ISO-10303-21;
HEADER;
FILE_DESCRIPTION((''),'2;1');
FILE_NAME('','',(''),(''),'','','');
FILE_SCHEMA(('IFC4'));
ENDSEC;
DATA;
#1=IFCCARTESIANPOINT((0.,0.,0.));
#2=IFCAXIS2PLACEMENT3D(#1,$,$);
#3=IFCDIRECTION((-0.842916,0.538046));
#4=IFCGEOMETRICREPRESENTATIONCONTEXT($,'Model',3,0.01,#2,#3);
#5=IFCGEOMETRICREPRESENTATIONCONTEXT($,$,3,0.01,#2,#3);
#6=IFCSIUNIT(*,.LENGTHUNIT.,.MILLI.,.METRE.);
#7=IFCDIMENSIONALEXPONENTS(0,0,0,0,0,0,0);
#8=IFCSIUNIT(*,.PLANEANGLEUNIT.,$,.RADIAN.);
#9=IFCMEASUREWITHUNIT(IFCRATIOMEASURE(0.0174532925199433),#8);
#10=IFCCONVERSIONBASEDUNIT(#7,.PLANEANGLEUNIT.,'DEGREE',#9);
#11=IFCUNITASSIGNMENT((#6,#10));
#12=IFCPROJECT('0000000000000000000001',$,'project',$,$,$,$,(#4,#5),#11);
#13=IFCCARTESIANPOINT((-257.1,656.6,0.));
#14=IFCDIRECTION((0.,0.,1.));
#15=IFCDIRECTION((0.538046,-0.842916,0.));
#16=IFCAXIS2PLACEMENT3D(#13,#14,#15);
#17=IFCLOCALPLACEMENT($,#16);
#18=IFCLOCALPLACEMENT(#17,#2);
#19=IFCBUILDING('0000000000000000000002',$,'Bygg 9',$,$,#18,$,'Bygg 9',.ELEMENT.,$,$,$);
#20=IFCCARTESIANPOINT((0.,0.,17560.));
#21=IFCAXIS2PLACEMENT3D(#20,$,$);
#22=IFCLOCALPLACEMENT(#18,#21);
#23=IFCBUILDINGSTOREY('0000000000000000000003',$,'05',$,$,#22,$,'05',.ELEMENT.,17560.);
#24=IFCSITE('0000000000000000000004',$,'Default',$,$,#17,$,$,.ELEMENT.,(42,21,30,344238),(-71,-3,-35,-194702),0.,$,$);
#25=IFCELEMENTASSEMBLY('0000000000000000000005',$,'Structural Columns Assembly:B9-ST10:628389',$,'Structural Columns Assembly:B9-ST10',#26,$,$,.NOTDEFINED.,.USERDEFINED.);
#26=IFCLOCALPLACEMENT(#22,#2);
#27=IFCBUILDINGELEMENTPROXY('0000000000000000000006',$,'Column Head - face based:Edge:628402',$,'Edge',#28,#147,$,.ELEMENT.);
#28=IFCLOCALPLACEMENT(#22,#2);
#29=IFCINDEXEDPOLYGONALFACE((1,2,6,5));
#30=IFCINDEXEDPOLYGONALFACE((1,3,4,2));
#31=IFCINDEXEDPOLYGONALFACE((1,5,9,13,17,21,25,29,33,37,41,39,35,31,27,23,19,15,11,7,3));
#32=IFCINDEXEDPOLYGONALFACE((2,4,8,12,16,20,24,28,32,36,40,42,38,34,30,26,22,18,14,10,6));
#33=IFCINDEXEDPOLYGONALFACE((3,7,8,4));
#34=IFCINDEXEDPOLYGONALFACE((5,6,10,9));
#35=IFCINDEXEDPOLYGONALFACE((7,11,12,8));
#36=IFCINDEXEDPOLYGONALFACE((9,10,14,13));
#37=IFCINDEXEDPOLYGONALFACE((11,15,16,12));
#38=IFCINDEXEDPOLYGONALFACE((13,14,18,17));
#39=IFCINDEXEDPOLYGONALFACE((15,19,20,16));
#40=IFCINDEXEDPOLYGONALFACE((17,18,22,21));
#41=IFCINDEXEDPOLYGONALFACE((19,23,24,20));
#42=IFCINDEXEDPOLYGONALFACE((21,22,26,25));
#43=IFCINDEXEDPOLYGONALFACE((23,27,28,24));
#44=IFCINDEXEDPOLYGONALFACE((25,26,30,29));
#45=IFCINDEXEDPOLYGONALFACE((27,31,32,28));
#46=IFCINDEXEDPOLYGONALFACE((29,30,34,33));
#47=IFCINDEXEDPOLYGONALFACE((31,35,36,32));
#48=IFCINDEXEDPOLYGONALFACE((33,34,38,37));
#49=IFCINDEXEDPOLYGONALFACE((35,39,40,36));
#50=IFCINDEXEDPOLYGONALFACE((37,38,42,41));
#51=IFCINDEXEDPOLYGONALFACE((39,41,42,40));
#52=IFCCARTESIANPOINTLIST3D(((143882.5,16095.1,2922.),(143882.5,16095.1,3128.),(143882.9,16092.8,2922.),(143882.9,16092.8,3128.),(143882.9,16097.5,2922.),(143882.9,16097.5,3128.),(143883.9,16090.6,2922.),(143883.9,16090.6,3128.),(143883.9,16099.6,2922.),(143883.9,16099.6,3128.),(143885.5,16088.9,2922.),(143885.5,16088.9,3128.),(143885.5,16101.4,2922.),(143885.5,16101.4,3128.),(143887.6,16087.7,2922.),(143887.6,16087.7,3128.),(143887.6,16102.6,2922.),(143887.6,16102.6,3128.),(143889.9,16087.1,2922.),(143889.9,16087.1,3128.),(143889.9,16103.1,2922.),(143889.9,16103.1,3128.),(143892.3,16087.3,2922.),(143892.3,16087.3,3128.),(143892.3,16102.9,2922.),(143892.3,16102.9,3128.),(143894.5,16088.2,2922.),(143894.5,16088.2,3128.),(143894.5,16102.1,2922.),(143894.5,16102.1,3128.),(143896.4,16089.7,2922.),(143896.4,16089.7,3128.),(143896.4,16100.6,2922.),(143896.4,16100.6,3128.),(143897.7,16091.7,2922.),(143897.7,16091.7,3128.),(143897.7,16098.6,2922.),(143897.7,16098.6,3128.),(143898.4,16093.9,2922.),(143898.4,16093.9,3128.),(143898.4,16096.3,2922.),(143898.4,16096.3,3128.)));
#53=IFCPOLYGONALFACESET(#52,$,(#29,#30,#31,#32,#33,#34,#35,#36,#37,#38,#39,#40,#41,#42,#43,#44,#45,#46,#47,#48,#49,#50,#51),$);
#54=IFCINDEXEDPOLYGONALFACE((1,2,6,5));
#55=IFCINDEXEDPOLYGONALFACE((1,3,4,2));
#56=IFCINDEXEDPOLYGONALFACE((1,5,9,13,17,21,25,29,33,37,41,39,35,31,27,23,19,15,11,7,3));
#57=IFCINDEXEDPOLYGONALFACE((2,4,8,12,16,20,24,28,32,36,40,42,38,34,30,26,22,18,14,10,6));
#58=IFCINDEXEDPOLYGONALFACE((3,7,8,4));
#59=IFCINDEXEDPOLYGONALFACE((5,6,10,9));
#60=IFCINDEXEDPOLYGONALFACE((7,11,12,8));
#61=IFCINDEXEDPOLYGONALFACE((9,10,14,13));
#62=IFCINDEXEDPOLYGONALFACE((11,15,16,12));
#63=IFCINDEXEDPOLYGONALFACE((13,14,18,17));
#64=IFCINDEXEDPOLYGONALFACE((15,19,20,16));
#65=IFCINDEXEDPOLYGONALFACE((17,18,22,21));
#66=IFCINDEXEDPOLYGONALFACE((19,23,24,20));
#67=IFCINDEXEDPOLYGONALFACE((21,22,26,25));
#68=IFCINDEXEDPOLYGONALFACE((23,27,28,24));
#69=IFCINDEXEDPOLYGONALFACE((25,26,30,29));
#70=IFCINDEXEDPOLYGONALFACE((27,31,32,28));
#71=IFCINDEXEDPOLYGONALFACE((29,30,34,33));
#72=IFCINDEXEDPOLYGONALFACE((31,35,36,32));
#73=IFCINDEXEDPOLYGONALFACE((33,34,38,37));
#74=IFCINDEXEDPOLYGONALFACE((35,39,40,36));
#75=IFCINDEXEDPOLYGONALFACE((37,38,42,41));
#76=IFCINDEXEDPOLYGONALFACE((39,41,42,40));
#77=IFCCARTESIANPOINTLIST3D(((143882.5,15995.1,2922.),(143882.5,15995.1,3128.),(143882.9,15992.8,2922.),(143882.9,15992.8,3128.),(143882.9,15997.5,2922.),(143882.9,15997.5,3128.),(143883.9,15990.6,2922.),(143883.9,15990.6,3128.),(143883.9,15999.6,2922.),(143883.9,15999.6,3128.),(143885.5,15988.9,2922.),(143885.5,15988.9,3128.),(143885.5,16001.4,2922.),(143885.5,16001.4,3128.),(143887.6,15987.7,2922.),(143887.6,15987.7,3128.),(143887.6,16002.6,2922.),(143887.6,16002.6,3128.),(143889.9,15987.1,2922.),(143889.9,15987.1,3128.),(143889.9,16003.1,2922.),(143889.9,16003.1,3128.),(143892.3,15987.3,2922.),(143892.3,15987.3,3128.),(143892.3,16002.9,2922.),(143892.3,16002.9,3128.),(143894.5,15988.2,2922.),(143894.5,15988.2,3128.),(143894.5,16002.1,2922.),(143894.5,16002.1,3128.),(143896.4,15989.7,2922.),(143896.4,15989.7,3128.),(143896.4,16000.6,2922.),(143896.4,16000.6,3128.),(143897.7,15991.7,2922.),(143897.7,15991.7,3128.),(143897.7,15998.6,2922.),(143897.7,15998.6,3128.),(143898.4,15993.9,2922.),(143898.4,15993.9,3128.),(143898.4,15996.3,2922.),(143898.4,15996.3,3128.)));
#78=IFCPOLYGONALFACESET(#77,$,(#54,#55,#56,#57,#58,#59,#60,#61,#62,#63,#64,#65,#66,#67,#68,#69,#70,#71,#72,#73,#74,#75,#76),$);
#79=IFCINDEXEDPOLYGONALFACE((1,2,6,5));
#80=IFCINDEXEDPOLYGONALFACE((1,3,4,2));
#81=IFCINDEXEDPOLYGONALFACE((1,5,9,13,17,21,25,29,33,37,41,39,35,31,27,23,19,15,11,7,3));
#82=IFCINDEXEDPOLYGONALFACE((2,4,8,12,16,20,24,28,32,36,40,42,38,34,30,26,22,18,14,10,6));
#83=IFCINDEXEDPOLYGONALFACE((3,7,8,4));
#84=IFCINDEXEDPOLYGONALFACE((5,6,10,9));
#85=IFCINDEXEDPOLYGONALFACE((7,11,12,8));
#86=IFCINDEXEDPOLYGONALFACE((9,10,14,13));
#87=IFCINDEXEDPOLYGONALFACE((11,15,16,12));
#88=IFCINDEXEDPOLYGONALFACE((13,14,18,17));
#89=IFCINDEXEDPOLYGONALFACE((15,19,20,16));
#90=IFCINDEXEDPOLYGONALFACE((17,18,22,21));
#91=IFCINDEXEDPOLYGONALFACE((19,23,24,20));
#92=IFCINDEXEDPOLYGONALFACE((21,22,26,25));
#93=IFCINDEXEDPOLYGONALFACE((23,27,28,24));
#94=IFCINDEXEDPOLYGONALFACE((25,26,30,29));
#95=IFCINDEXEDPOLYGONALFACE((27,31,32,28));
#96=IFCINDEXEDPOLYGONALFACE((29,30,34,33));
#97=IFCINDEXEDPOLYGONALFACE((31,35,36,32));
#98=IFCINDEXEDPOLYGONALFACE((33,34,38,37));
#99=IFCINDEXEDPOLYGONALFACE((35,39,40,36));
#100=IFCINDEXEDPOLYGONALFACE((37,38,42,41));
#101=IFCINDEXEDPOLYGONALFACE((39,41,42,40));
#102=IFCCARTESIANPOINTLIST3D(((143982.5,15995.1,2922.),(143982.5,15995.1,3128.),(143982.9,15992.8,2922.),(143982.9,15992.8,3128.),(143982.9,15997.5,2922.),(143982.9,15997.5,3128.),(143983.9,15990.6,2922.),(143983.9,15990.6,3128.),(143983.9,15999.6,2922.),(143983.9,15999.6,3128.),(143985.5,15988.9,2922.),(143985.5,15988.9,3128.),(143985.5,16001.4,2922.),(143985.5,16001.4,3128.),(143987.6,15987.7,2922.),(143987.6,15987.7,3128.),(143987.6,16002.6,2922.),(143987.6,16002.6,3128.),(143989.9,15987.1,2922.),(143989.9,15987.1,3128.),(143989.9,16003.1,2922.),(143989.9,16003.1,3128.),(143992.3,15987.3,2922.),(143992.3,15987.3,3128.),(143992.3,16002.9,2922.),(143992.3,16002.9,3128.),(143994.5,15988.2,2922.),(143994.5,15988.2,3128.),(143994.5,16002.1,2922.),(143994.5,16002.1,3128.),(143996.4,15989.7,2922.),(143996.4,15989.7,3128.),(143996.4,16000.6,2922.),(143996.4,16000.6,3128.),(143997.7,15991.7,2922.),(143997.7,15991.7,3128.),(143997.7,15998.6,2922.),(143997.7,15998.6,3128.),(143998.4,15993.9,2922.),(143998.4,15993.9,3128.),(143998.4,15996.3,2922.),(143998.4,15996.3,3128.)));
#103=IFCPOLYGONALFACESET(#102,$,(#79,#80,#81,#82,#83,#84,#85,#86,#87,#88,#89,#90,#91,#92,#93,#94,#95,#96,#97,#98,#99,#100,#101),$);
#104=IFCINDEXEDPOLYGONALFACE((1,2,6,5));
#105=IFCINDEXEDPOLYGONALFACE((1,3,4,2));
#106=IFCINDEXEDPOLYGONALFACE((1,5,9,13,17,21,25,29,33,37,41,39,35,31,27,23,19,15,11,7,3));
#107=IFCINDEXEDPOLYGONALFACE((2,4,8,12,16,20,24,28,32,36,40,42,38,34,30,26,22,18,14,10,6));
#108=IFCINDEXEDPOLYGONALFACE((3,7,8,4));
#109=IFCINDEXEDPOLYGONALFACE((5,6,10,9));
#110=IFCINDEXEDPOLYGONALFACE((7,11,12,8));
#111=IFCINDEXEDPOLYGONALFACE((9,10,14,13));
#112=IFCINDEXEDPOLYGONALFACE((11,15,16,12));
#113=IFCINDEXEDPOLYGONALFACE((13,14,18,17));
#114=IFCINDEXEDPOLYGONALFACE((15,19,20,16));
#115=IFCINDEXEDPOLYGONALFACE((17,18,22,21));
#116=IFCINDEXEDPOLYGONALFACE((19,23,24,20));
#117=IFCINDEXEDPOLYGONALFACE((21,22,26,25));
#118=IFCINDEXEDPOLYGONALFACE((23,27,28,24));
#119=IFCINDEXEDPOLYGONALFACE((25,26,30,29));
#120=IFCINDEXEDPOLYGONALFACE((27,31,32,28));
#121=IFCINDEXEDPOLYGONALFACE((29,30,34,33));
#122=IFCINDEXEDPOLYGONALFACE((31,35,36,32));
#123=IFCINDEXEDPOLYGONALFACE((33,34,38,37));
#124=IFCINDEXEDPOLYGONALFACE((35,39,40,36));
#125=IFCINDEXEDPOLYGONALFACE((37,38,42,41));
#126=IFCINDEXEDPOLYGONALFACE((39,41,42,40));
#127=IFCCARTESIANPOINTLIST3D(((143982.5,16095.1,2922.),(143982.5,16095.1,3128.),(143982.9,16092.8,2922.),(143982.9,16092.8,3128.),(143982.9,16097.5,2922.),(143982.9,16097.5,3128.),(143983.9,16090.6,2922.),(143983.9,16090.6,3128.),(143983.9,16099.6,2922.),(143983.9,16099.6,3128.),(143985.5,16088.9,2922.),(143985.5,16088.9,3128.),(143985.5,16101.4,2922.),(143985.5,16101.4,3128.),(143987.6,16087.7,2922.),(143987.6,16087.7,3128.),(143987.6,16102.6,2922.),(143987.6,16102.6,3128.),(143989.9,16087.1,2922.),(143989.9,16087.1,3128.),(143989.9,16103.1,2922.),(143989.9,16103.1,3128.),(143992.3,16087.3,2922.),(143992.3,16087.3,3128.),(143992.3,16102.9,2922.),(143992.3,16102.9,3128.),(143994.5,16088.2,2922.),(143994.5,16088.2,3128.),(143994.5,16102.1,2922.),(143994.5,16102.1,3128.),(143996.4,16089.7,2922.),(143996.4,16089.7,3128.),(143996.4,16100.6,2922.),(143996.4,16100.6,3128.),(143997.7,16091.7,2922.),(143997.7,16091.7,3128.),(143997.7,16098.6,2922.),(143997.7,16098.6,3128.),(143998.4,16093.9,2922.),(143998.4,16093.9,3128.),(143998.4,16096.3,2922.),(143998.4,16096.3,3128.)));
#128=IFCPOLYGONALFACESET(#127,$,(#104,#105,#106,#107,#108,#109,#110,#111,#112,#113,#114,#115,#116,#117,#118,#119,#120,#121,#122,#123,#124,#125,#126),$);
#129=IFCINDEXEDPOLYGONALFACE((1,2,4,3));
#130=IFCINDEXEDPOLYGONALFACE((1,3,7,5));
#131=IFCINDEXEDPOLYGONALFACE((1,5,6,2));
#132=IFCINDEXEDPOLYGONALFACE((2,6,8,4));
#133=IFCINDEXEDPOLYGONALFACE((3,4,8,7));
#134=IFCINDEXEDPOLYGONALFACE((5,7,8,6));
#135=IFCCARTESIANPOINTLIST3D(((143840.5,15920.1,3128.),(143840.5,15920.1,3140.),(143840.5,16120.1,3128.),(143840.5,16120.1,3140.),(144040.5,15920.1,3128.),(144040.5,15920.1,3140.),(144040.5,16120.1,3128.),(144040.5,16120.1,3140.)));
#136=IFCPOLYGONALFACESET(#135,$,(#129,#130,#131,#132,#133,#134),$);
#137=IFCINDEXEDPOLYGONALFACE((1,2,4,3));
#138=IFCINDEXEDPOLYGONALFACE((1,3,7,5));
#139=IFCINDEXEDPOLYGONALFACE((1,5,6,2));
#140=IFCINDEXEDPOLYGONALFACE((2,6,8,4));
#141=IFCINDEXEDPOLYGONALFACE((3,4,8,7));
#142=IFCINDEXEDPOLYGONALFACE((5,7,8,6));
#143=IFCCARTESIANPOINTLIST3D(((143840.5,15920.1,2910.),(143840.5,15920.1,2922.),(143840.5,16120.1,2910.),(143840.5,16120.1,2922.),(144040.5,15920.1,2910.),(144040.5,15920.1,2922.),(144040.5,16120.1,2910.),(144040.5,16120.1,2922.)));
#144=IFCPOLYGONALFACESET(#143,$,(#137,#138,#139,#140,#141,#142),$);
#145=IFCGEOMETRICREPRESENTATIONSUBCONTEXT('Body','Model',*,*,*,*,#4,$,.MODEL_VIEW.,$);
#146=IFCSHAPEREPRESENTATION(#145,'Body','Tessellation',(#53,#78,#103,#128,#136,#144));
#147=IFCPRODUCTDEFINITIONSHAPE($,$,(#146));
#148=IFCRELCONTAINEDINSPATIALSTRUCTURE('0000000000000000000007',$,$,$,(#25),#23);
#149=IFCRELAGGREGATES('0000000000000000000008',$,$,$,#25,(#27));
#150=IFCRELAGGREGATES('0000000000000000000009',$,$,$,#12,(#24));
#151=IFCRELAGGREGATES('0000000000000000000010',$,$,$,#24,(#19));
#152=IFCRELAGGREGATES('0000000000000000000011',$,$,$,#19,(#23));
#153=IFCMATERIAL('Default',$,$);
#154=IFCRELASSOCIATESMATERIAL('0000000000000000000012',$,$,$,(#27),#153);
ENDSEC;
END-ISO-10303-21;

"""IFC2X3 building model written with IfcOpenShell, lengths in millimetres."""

from ifc_helpers import new_model, entity, si_unit, converted_unit, direction, frame, frame_2d, origin, origin_2d_with_axis, place, context, subcontext, project, spatial, rectangle, circle, extrude, source, transform, mapped, material, element, aggregate, save


model = new_model("IFC2X3")

# Units and contexts
model_context = context("Model", 3, precision=0.01, world=origin(), true_north=direction((-0.842916, 0.538046)))
context_of_model = context(None, 3, precision=0.01, world=origin(), true_north=direction((-0.842916, 0.538046)))
body_context = subcontext(model_context, "Body", "Model", "MODEL_VIEW")
ifc_project = project(units=[si_unit("LENGTHUNIT", "METRE", prefix="MILLI"), converted_unit("PLANEANGLEUNIT", "DEGREE", entity("IfcRatioMeasure", 0.0174532925199433), si_unit("PLANEANGLEUNIT", "RADIAN"), dimensions=[0, 0, 0, 0, 0, 0, 0])], contexts=[model_context, context_of_model])

# Site, building, storey
site_placement = place(None, frame((-257.1, 656.6, 0.0), z_axis=(0.0, 0.0, 1.0), x_axis=(0.538046, -0.842916, 0.0)))
site = spatial("IfcSite", under=ifc_project, at=site_placement, Name="Default", CompositionType="ELEMENT", RefLatitude=(42, 21, 30, 344238), RefLongitude=(-71, -3, -35, -194702), RefElevation=0.0)
building_placement = place(site_placement, origin())
building = spatial("IfcBuilding", under=site, at=building_placement, Name="Bygg 9", LongName="Bygg 9", CompositionType="ELEMENT")
storey_placement = place(building_placement, frame((0.0, 0.0, 17560.0)))
storey = spatial("IfcBuildingStorey", under=building, at=storey_placement, Name="05", LongName="05", CompositionType="ELEMENT", Elevation=17560.0)

# Element assembly
assembly_1_placement = place(storey_placement, origin())
assembly_1 = element("IfcElementAssembly", 1, at=assembly_1_placement, inside=storey, Name="Structural Columns Assembly:B9-ST10:628389", ObjectType="Structural Columns Assembly:B9-ST10", AssemblyPlace="NOTDEFINED", PredefinedType="USERDEFINED")

# Building element proxy
ifc_material_1 = material(Name="Default")
shared_shape_1 = source(origin(), body_context, "Body", "SweptSolid", [
    extrude(circle(Radius=8.0, at=frame_2d((0.0, 0.0), x_axis=(1.0, 0.0))), frame((50.0, -75.0, 12.0)), (0.0, 0.0, 1.0), 206.0),
    extrude(circle(Radius=8.0, at=frame_2d((0.0, 0.0), x_axis=(1.0, 0.0))), frame((50.0, 25.0, 12.0)), (0.0, 0.0, 1.0), 206.0),
    extrude(circle(Radius=8.0, at=frame_2d((0.0, 0.0), x_axis=(1.0, 0.0))), frame((-50.0, 25.0, 12.0)), (0.0, 0.0, 1.0), 206.0),
    extrude(circle(Radius=8.0, at=frame_2d((0.0, 0.0), x_axis=(1.0, 0.0))), frame((-50.0, -75.0, 12.0)), (0.0, 0.0, 1.0), 206.0),
    extrude(rectangle(XDim=200.0, YDim=200.0, at=origin_2d_with_axis()), frame((0.0, 0.0, 218.0), z_axis=(0.0, 0.0, 1.0), x_axis=(-1.0, 0.0, 0.0)), (0.0, 0.0, 1.0), 12.0),
    extrude(rectangle(XDim=200.0, YDim=200.0, at=origin_2d_with_axis()), frame((0.0, 0.0, 0.0), z_axis=(0.0, 0.0, 1.0), x_axis=(0.0, 1.0, 0.0)), (0.0, 0.0, 1.0), 12.0),
])
proxy_1_placement = place(assembly_1_placement, frame((143940.5, 16020.1, 2910.0), z_axis=(0.0, 0.0, 1.0), x_axis=(-1.0, 0.0, 0.0)))
proxy_1 = element("IfcBuildingElementProxy", 2, at=proxy_1_placement, material=ifc_material_1, Name="Column Head - face based:Edge:628402", ObjectType="Edge", CompositionType="ELEMENT", context=body_context, shape_type="MappedRepresentation", body=[
    mapped(shared_shape_1, transform((0.0, 0.0, 0.0), scale=1.0)),
])
aggregate(assembly_1, [proxy_1])

save(model, "model.ifc")
